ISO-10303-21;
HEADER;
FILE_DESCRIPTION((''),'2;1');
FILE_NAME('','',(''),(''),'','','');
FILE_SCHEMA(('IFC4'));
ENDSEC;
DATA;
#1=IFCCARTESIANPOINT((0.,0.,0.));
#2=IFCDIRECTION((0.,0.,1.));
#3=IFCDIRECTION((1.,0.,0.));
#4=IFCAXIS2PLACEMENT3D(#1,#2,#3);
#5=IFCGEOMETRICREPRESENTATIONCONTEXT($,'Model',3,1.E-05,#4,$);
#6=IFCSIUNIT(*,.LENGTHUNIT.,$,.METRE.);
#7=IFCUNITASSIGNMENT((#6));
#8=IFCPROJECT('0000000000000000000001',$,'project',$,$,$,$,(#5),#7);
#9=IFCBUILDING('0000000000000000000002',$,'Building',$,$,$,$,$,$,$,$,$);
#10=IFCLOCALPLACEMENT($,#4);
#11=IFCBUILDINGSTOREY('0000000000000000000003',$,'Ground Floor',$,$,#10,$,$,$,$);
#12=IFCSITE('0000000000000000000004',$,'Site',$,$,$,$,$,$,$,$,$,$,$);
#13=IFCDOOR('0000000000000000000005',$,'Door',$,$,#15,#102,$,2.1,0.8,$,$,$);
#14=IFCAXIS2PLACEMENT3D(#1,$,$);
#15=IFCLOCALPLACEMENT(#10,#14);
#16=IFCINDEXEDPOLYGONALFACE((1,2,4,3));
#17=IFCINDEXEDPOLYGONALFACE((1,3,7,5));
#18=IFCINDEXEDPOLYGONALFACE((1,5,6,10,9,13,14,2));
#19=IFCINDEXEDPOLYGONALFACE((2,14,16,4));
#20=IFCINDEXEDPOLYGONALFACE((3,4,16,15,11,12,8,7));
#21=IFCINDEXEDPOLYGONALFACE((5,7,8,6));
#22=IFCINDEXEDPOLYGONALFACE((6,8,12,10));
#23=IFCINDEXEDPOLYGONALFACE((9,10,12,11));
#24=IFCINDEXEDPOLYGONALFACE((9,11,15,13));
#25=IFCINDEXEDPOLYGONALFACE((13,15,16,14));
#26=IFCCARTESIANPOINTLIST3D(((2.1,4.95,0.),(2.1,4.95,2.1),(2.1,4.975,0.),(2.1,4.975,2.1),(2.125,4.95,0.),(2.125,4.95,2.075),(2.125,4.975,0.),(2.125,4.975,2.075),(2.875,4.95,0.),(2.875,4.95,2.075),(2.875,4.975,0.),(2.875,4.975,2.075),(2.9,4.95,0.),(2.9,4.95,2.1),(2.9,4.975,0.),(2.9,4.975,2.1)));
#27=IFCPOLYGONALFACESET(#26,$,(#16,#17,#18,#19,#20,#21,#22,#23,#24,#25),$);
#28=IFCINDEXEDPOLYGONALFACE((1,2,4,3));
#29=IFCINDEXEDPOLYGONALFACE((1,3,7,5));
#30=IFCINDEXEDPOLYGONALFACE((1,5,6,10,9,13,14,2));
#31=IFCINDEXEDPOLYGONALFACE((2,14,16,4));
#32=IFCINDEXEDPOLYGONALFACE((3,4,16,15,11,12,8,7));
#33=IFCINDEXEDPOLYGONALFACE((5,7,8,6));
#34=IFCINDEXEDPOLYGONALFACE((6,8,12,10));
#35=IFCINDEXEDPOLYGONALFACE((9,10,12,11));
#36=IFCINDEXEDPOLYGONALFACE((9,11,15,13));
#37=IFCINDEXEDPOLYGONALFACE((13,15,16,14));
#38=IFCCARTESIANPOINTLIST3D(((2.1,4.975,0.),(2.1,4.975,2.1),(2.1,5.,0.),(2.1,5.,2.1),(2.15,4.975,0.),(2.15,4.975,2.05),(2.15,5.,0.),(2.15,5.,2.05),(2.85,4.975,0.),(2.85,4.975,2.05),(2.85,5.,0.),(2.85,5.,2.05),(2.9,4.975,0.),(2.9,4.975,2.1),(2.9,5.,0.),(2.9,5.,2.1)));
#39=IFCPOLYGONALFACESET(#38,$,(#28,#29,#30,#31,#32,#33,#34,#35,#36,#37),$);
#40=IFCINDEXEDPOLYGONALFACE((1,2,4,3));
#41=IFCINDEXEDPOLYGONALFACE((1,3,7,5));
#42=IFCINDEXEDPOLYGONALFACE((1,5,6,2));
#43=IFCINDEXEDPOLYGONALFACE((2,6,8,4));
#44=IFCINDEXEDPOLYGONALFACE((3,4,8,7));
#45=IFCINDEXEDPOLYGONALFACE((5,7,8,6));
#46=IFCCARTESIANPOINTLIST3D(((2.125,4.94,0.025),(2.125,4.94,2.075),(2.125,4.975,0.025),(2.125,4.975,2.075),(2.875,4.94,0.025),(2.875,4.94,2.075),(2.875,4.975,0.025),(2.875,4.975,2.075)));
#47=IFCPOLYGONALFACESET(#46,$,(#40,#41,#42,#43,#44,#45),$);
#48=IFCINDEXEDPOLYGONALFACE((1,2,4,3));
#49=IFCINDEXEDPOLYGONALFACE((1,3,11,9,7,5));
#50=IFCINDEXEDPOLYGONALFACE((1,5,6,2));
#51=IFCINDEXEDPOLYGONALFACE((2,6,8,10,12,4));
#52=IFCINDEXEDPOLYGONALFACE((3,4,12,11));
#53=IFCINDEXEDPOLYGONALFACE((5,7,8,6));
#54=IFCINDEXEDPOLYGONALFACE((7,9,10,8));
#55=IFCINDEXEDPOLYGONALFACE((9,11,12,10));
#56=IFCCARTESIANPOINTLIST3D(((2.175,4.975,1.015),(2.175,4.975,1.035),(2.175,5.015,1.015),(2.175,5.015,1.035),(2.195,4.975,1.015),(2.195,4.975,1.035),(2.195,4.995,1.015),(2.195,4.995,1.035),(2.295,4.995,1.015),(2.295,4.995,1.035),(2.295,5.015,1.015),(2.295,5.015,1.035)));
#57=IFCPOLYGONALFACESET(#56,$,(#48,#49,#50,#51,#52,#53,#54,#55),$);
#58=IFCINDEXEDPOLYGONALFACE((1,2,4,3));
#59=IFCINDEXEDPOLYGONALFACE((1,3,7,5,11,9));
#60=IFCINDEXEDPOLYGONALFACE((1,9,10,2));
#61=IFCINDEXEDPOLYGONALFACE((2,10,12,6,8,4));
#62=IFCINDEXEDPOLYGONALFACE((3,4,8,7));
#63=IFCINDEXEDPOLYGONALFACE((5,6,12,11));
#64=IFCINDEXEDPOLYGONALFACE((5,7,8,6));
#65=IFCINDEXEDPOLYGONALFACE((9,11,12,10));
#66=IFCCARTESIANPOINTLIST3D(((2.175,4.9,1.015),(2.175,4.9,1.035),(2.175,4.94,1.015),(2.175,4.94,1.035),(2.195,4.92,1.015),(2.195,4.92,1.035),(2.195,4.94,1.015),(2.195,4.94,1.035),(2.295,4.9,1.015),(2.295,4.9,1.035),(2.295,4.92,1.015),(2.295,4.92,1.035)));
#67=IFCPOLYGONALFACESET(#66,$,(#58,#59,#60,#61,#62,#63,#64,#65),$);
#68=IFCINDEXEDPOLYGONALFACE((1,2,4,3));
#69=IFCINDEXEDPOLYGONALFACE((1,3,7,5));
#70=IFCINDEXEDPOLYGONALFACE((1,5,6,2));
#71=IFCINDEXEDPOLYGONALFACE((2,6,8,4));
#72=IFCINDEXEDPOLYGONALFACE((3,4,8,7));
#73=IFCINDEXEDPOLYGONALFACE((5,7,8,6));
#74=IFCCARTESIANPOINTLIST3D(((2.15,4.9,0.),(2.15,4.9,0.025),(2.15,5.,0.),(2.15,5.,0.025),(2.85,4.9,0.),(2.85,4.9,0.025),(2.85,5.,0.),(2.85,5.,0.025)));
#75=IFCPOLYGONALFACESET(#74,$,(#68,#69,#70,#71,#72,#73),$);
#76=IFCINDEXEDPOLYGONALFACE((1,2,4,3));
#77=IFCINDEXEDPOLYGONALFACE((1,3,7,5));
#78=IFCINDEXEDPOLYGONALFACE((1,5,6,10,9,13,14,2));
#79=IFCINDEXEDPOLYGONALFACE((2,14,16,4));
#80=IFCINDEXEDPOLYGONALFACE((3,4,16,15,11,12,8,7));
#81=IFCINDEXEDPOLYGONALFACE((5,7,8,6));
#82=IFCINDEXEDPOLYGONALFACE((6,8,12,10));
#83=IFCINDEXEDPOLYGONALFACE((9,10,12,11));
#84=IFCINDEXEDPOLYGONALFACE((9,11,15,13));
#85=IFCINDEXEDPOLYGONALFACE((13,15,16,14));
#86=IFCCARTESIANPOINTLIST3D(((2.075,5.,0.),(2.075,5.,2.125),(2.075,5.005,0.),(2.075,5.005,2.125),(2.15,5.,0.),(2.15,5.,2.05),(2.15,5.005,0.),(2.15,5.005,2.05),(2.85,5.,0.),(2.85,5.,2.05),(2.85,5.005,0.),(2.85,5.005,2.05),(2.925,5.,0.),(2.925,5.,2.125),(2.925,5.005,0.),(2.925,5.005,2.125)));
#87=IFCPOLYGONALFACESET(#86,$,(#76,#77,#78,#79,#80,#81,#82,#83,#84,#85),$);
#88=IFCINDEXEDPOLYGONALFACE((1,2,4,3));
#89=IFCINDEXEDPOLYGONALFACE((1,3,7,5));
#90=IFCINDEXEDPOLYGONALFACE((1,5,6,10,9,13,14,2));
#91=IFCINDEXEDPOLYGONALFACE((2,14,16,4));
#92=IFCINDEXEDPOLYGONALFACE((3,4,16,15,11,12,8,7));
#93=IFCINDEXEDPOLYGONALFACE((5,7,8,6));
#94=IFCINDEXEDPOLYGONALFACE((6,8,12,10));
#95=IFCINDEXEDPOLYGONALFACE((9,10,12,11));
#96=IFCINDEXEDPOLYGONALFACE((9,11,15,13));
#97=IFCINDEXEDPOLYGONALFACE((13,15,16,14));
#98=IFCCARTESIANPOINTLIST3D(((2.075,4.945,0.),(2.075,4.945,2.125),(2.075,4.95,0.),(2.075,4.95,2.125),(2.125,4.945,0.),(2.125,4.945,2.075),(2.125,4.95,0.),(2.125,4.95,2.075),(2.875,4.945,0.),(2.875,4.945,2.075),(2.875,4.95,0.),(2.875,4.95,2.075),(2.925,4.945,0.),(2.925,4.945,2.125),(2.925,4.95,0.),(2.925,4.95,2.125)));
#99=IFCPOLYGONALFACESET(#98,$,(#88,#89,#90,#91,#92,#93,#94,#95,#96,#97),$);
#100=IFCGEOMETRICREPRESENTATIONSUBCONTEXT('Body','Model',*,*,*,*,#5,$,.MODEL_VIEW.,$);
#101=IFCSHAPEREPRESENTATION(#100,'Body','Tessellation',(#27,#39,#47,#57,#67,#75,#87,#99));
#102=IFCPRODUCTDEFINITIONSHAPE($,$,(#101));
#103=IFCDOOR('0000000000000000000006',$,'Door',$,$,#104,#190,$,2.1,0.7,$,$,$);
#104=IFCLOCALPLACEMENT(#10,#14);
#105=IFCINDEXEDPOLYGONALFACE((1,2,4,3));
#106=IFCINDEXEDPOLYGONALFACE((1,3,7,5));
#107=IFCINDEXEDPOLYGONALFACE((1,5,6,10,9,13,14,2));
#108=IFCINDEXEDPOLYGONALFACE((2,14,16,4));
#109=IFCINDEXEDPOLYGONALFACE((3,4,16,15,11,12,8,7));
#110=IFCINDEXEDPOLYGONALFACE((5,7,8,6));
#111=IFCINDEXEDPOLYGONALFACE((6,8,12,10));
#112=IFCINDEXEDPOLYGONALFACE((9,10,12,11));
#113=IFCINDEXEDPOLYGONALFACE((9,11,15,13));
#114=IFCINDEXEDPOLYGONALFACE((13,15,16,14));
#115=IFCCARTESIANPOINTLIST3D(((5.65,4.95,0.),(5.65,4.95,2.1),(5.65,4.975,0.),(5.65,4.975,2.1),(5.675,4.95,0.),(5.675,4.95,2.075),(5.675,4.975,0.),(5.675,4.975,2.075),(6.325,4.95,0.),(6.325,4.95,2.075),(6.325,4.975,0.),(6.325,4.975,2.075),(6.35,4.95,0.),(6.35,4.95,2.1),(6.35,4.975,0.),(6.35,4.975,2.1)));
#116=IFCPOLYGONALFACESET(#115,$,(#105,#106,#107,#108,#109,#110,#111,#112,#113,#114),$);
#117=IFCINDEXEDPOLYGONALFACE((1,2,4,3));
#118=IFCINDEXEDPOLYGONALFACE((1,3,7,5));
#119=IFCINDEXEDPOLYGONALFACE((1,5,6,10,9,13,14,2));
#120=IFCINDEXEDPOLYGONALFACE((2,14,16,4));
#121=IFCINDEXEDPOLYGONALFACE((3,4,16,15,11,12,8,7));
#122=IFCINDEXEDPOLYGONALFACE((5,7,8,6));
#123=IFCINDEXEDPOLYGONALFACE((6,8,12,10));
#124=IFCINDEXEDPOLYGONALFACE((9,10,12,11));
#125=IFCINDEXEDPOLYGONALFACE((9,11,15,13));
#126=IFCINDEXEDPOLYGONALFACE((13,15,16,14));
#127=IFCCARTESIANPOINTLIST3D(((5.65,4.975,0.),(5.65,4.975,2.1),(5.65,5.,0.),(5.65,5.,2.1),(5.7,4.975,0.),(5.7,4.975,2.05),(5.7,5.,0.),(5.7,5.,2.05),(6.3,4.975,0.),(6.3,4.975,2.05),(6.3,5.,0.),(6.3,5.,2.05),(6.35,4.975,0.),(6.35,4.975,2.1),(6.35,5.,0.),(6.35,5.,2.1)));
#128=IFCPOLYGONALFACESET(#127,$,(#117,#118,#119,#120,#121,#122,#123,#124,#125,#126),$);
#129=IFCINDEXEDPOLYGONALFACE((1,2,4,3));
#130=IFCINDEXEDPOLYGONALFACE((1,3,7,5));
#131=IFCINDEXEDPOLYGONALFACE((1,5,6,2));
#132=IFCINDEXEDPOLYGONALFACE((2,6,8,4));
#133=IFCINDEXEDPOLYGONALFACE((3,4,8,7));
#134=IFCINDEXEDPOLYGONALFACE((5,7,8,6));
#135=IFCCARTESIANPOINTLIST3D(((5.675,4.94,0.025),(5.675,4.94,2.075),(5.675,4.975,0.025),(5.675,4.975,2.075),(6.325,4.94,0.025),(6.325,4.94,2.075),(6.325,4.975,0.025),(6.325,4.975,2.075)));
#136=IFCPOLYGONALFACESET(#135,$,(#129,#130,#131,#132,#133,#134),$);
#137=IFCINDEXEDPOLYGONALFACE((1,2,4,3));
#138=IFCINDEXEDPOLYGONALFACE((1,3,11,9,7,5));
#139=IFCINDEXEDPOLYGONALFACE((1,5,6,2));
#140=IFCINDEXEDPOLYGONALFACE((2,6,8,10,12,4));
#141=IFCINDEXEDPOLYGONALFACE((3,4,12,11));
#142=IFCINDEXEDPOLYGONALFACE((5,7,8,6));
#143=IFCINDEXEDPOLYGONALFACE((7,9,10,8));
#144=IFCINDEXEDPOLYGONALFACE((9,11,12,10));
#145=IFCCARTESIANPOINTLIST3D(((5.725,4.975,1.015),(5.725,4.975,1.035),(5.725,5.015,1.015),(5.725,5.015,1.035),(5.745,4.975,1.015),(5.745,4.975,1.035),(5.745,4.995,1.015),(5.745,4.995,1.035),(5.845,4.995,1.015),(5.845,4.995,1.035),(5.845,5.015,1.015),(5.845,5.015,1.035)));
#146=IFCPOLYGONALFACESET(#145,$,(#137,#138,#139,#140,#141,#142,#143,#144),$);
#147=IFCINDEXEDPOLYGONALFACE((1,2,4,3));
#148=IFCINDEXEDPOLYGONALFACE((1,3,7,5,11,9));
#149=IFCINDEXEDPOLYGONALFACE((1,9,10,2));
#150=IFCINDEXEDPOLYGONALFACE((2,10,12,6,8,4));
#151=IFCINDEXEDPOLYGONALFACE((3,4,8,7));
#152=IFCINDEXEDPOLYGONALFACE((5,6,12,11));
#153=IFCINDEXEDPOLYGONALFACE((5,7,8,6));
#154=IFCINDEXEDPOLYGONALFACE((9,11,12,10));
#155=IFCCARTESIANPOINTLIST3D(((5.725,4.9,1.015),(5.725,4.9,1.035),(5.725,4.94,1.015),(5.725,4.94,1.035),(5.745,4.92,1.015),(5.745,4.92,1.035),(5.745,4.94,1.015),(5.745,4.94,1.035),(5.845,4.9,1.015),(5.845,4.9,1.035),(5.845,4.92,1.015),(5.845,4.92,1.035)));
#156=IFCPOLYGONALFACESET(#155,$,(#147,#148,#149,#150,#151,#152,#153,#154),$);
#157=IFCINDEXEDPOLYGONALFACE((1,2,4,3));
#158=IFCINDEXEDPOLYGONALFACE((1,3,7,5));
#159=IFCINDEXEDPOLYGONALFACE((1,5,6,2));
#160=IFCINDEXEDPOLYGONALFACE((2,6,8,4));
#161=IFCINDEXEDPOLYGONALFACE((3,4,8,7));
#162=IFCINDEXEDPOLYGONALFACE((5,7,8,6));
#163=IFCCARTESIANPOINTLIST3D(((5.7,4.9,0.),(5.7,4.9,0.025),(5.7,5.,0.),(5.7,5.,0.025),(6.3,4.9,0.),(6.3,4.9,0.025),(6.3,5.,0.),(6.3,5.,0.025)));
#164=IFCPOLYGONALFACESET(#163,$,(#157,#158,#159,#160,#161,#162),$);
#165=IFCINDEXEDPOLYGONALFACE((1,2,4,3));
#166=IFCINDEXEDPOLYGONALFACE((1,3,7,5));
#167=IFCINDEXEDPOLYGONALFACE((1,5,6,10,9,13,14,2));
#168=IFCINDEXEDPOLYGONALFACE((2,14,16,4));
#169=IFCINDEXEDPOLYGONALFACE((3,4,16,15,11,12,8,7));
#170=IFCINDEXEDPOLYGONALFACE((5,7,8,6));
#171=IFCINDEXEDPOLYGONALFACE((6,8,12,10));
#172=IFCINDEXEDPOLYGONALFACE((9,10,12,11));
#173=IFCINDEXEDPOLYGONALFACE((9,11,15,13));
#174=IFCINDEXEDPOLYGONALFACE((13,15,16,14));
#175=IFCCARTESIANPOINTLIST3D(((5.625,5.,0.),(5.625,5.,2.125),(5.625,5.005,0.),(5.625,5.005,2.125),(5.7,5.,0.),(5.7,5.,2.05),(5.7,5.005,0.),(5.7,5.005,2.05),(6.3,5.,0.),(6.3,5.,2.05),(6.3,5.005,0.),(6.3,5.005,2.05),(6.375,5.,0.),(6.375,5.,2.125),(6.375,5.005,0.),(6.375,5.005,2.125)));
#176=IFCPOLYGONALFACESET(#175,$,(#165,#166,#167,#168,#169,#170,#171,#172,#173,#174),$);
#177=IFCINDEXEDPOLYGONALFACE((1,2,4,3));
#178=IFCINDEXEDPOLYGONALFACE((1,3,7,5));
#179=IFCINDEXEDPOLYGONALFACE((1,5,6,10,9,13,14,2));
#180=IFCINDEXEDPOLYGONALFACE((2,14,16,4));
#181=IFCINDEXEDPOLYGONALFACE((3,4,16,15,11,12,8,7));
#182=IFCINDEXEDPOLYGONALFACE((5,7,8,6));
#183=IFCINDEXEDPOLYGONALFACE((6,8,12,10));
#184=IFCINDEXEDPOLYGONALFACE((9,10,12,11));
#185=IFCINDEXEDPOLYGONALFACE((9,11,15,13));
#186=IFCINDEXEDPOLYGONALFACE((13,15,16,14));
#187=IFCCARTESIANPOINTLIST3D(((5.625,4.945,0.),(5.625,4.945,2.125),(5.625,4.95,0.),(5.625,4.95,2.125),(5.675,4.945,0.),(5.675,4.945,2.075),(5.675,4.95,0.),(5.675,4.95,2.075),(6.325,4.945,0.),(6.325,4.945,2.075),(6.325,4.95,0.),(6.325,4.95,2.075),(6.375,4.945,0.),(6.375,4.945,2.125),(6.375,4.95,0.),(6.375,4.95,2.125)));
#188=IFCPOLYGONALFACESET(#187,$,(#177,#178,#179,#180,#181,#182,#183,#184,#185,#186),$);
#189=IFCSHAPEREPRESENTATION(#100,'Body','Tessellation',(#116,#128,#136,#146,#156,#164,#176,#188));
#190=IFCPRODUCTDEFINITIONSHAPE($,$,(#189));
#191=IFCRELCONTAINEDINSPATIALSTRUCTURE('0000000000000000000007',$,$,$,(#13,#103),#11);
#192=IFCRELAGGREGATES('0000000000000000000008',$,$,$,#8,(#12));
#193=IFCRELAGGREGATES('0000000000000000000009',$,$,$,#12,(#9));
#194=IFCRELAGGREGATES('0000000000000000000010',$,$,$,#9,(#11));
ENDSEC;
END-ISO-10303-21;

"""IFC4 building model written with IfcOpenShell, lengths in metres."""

from ifc_helpers import new_model, si_unit, frame, origin_with_axes, place, context, subcontext, project, spatial, line, indexed_curve, outline, extrude, element, save


model = new_model("IFC4")

# Units and contexts
model_context = context("Model", 3, precision=1e-05, world=origin_with_axes())
body_context = subcontext(model_context, "Body", "Model", "MODEL_VIEW")
ifc_project = project(units=[si_unit("LENGTHUNIT", "METRE")], contexts=[model_context])

# Site, building, storey
site = spatial("IfcSite", under=ifc_project, Name="Site")
building = spatial("IfcBuilding", under=site, Name="Building")
storey_placement = place(None, origin_with_axes())
storey = spatial("IfcBuildingStorey", under=building, at=storey_placement, Name="Ground Floor")

# Doors
door_1_placement = place(storey_placement, frame((2.9, 5.0, 0.0), z_axis=(0.0, 0.0, 1.0), x_axis=(-1.0, 0.0, 0.0)))
element("IfcDoor", 1, at=door_1_placement, inside=storey, Name="Door", OverallHeight=2.1, OverallWidth=0.8, context=body_context, shape_type="SweptSolid", body=[
    extrude(outline(indexed_curve([(0.0, 0.0), (0.0, 2.1), (0.8, 2.1), (0.8, 0.0), (0.775, 0.0), (0.775, 2.075), (0.025, 2.075), (0.025, 0.0)], segments=[line(1, 2, 3, 4, 5, 6, 7, 8, 1)])), frame((0.0, 0.025, 0.0), z_axis=(0.0, -1.0, 0.0), x_axis=(1.0, 0.0, 0.0)), (0.0, 0.0, -1.0), 0.025),
    extrude(outline(indexed_curve([(0.0, 0.0), (0.0, 2.1), (0.8, 2.1), (0.8, 0.0), (0.75, 0.0), (0.75, 2.05), (0.05, 2.05), (0.05, 0.0)], segments=[line(1, 2, 3, 4, 5, 6, 7, 8, 1)])), frame((0.0, 0.0, 0.0), z_axis=(0.0, -1.0, 0.0), x_axis=(1.0, 0.0, 0.0)), (0.0, 0.0, -1.0), 0.025),
    extrude(outline(indexed_curve([(0.0, 0.0), (0.75, 0.0), (0.75, 0.035), (0.0, 0.035)], segments=[line(1, 2, 3, 4, 1)])), frame((0.025, 0.025, 0.025), z_axis=(0.0, 0.0, 1.0), x_axis=(1.0, 0.0, 0.0)), (0.0, 0.0, 1.0), 2.05),
    extrude(outline(indexed_curve([(0.0, 0.0), (0.0, -0.04), (-0.12, -0.04), (-0.12, -0.02), (-0.02, -0.02), (-0.02, 0.0)], segments=[line(1, 2, 3, 4, 5, 6, 1)])), frame((0.725, 0.025, 1.015), z_axis=(0.0, 0.0, 1.0), x_axis=(1.0, 0.0, 0.0)), (0.0, 0.0, 1.0), 0.02),
    extrude(outline(indexed_curve([(0.0, 0.0), (0.0, 0.04), (-0.12, 0.04), (-0.12, 0.02), (-0.02, 0.02), (-0.02, 0.0)], segments=[line(1, 2, 3, 4, 5, 6, 1)])), frame((0.725, 0.06, 1.015), z_axis=(0.0, 0.0, 1.0), x_axis=(1.0, 0.0, 0.0)), (0.0, 0.0, 1.0), 0.02),
    extrude(outline(indexed_curve([(0.0, 0.0), (0.7, 0.0), (0.7, 0.1), (0.0, 0.1)], segments=[line(1, 2, 3, 4, 1)])), frame((0.05, 0.0, 0.0), z_axis=(0.0, 0.0, 1.0), x_axis=(1.0, 0.0, 0.0)), (0.0, 0.0, 1.0), 0.025),
    extrude(outline(indexed_curve([(0.0, 0.0), (0.0, 2.125), (0.85, 2.125), (0.85, 0.0), (0.775, 0.0), (0.775, 2.05), (0.075, 2.05), (0.075, 0.0)], segments=[line(1, 2, 3, 4, 5, 6, 7, 8, 1)])), frame((-0.025, -0.005, 0.0), z_axis=(0.0, -1.0, 0.0), x_axis=(1.0, 0.0, 0.0)), (0.0, 0.0, -1.0), 0.005),
    extrude(outline(indexed_curve([(0.0, 0.0), (0.0, 2.125), (0.85, 2.125), (0.85, 0.0), (0.8, 0.0), (0.8, 2.075), (0.05, 2.075), (0.05, 0.0)], segments=[line(1, 2, 3, 4, 5, 6, 7, 8, 1)])), frame((-0.025, 0.05, 0.0), z_axis=(0.0, -1.0, 0.0), x_axis=(1.0, 0.0, 0.0)), (0.0, 0.0, -1.0), 0.005),
])
door_2_placement = place(storey_placement, frame((6.35, 5.0, 0.0), z_axis=(0.0, 0.0, 1.0), x_axis=(-1.0, 0.0, 0.0)))
element("IfcDoor", 2, at=door_2_placement, inside=storey, Name="Door", OverallHeight=2.1, OverallWidth=0.7, context=body_context, shape_type="SweptSolid", body=[
    extrude(outline(indexed_curve([(0.0, 0.0), (0.0, 2.1), (0.7, 2.1), (0.7, 0.0), (0.675, 0.0), (0.675, 2.075), (0.025, 2.075), (0.025, 0.0)], segments=[line(1, 2, 3, 4, 5, 6, 7, 8, 1)])), frame((0.0, 0.025, 0.0), z_axis=(0.0, -1.0, 0.0), x_axis=(1.0, 0.0, 0.0)), (0.0, 0.0, -1.0), 0.025),
    extrude(outline(indexed_curve([(0.0, 0.0), (0.0, 2.1), (0.7, 2.1), (0.7, 0.0), (0.65, 0.0), (0.65, 2.05), (0.05, 2.05), (0.05, 0.0)], segments=[line(1, 2, 3, 4, 5, 6, 7, 8, 1)])), frame((0.0, 0.0, 0.0), z_axis=(0.0, -1.0, 0.0), x_axis=(1.0, 0.0, 0.0)), (0.0, 0.0, -1.0), 0.025),
    extrude(outline(indexed_curve([(0.0, 0.0), (0.65, 0.0), (0.65, 0.035), (0.0, 0.035)], segments=[line(1, 2, 3, 4, 1)])), frame((0.025, 0.025, 0.025), z_axis=(0.0, 0.0, 1.0), x_axis=(1.0, 0.0, 0.0)), (0.0, 0.0, 1.0), 2.05),
    extrude(outline(indexed_curve([(0.0, 0.0), (0.0, -0.04), (-0.12, -0.04), (-0.12, -0.02), (-0.02, -0.02), (-0.02, 0.0)], segments=[line(1, 2, 3, 4, 5, 6, 1)])), frame((0.625, 0.025, 1.015), z_axis=(0.0, 0.0, 1.0), x_axis=(1.0, 0.0, 0.0)), (0.0, 0.0, 1.0), 0.02),
    extrude(outline(indexed_curve([(0.0, 0.0), (0.0, 0.04), (-0.12, 0.04), (-0.12, 0.02), (-0.02, 0.02), (-0.02, 0.0)], segments=[line(1, 2, 3, 4, 5, 6, 1)])), frame((0.625, 0.06, 1.015), z_axis=(0.0, 0.0, 1.0), x_axis=(1.0, 0.0, 0.0)), (0.0, 0.0, 1.0), 0.02),
    extrude(outline(indexed_curve([(0.0, 0.0), (0.6, 0.0), (0.6, 0.1), (0.0, 0.1)], segments=[line(1, 2, 3, 4, 1)])), frame((0.05, 0.0, 0.0), z_axis=(0.0, 0.0, 1.0), x_axis=(1.0, 0.0, 0.0)), (0.0, 0.0, 1.0), 0.025),
    extrude(outline(indexed_curve([(0.0, 0.0), (0.0, 2.125), (0.75, 2.125), (0.75, 0.0), (0.675, 0.0), (0.675, 2.05), (0.075, 2.05), (0.075, 0.0)], segments=[line(1, 2, 3, 4, 5, 6, 7, 8, 1)])), frame((-0.025, -0.005, 0.0), z_axis=(0.0, -1.0, 0.0), x_axis=(1.0, 0.0, 0.0)), (0.0, 0.0, -1.0), 0.005),
    extrude(outline(indexed_curve([(0.0, 0.0), (0.0, 2.125), (0.75, 2.125), (0.75, 0.0), (0.7, 0.0), (0.7, 2.075), (0.05, 2.075), (0.05, 0.0)], segments=[line(1, 2, 3, 4, 5, 6, 7, 8, 1)])), frame((-0.025, 0.05, 0.0), z_axis=(0.0, -1.0, 0.0), x_axis=(1.0, 0.0, 0.0)), (0.0, 0.0, -1.0), 0.005),
])

save(model, "model.ifc")
